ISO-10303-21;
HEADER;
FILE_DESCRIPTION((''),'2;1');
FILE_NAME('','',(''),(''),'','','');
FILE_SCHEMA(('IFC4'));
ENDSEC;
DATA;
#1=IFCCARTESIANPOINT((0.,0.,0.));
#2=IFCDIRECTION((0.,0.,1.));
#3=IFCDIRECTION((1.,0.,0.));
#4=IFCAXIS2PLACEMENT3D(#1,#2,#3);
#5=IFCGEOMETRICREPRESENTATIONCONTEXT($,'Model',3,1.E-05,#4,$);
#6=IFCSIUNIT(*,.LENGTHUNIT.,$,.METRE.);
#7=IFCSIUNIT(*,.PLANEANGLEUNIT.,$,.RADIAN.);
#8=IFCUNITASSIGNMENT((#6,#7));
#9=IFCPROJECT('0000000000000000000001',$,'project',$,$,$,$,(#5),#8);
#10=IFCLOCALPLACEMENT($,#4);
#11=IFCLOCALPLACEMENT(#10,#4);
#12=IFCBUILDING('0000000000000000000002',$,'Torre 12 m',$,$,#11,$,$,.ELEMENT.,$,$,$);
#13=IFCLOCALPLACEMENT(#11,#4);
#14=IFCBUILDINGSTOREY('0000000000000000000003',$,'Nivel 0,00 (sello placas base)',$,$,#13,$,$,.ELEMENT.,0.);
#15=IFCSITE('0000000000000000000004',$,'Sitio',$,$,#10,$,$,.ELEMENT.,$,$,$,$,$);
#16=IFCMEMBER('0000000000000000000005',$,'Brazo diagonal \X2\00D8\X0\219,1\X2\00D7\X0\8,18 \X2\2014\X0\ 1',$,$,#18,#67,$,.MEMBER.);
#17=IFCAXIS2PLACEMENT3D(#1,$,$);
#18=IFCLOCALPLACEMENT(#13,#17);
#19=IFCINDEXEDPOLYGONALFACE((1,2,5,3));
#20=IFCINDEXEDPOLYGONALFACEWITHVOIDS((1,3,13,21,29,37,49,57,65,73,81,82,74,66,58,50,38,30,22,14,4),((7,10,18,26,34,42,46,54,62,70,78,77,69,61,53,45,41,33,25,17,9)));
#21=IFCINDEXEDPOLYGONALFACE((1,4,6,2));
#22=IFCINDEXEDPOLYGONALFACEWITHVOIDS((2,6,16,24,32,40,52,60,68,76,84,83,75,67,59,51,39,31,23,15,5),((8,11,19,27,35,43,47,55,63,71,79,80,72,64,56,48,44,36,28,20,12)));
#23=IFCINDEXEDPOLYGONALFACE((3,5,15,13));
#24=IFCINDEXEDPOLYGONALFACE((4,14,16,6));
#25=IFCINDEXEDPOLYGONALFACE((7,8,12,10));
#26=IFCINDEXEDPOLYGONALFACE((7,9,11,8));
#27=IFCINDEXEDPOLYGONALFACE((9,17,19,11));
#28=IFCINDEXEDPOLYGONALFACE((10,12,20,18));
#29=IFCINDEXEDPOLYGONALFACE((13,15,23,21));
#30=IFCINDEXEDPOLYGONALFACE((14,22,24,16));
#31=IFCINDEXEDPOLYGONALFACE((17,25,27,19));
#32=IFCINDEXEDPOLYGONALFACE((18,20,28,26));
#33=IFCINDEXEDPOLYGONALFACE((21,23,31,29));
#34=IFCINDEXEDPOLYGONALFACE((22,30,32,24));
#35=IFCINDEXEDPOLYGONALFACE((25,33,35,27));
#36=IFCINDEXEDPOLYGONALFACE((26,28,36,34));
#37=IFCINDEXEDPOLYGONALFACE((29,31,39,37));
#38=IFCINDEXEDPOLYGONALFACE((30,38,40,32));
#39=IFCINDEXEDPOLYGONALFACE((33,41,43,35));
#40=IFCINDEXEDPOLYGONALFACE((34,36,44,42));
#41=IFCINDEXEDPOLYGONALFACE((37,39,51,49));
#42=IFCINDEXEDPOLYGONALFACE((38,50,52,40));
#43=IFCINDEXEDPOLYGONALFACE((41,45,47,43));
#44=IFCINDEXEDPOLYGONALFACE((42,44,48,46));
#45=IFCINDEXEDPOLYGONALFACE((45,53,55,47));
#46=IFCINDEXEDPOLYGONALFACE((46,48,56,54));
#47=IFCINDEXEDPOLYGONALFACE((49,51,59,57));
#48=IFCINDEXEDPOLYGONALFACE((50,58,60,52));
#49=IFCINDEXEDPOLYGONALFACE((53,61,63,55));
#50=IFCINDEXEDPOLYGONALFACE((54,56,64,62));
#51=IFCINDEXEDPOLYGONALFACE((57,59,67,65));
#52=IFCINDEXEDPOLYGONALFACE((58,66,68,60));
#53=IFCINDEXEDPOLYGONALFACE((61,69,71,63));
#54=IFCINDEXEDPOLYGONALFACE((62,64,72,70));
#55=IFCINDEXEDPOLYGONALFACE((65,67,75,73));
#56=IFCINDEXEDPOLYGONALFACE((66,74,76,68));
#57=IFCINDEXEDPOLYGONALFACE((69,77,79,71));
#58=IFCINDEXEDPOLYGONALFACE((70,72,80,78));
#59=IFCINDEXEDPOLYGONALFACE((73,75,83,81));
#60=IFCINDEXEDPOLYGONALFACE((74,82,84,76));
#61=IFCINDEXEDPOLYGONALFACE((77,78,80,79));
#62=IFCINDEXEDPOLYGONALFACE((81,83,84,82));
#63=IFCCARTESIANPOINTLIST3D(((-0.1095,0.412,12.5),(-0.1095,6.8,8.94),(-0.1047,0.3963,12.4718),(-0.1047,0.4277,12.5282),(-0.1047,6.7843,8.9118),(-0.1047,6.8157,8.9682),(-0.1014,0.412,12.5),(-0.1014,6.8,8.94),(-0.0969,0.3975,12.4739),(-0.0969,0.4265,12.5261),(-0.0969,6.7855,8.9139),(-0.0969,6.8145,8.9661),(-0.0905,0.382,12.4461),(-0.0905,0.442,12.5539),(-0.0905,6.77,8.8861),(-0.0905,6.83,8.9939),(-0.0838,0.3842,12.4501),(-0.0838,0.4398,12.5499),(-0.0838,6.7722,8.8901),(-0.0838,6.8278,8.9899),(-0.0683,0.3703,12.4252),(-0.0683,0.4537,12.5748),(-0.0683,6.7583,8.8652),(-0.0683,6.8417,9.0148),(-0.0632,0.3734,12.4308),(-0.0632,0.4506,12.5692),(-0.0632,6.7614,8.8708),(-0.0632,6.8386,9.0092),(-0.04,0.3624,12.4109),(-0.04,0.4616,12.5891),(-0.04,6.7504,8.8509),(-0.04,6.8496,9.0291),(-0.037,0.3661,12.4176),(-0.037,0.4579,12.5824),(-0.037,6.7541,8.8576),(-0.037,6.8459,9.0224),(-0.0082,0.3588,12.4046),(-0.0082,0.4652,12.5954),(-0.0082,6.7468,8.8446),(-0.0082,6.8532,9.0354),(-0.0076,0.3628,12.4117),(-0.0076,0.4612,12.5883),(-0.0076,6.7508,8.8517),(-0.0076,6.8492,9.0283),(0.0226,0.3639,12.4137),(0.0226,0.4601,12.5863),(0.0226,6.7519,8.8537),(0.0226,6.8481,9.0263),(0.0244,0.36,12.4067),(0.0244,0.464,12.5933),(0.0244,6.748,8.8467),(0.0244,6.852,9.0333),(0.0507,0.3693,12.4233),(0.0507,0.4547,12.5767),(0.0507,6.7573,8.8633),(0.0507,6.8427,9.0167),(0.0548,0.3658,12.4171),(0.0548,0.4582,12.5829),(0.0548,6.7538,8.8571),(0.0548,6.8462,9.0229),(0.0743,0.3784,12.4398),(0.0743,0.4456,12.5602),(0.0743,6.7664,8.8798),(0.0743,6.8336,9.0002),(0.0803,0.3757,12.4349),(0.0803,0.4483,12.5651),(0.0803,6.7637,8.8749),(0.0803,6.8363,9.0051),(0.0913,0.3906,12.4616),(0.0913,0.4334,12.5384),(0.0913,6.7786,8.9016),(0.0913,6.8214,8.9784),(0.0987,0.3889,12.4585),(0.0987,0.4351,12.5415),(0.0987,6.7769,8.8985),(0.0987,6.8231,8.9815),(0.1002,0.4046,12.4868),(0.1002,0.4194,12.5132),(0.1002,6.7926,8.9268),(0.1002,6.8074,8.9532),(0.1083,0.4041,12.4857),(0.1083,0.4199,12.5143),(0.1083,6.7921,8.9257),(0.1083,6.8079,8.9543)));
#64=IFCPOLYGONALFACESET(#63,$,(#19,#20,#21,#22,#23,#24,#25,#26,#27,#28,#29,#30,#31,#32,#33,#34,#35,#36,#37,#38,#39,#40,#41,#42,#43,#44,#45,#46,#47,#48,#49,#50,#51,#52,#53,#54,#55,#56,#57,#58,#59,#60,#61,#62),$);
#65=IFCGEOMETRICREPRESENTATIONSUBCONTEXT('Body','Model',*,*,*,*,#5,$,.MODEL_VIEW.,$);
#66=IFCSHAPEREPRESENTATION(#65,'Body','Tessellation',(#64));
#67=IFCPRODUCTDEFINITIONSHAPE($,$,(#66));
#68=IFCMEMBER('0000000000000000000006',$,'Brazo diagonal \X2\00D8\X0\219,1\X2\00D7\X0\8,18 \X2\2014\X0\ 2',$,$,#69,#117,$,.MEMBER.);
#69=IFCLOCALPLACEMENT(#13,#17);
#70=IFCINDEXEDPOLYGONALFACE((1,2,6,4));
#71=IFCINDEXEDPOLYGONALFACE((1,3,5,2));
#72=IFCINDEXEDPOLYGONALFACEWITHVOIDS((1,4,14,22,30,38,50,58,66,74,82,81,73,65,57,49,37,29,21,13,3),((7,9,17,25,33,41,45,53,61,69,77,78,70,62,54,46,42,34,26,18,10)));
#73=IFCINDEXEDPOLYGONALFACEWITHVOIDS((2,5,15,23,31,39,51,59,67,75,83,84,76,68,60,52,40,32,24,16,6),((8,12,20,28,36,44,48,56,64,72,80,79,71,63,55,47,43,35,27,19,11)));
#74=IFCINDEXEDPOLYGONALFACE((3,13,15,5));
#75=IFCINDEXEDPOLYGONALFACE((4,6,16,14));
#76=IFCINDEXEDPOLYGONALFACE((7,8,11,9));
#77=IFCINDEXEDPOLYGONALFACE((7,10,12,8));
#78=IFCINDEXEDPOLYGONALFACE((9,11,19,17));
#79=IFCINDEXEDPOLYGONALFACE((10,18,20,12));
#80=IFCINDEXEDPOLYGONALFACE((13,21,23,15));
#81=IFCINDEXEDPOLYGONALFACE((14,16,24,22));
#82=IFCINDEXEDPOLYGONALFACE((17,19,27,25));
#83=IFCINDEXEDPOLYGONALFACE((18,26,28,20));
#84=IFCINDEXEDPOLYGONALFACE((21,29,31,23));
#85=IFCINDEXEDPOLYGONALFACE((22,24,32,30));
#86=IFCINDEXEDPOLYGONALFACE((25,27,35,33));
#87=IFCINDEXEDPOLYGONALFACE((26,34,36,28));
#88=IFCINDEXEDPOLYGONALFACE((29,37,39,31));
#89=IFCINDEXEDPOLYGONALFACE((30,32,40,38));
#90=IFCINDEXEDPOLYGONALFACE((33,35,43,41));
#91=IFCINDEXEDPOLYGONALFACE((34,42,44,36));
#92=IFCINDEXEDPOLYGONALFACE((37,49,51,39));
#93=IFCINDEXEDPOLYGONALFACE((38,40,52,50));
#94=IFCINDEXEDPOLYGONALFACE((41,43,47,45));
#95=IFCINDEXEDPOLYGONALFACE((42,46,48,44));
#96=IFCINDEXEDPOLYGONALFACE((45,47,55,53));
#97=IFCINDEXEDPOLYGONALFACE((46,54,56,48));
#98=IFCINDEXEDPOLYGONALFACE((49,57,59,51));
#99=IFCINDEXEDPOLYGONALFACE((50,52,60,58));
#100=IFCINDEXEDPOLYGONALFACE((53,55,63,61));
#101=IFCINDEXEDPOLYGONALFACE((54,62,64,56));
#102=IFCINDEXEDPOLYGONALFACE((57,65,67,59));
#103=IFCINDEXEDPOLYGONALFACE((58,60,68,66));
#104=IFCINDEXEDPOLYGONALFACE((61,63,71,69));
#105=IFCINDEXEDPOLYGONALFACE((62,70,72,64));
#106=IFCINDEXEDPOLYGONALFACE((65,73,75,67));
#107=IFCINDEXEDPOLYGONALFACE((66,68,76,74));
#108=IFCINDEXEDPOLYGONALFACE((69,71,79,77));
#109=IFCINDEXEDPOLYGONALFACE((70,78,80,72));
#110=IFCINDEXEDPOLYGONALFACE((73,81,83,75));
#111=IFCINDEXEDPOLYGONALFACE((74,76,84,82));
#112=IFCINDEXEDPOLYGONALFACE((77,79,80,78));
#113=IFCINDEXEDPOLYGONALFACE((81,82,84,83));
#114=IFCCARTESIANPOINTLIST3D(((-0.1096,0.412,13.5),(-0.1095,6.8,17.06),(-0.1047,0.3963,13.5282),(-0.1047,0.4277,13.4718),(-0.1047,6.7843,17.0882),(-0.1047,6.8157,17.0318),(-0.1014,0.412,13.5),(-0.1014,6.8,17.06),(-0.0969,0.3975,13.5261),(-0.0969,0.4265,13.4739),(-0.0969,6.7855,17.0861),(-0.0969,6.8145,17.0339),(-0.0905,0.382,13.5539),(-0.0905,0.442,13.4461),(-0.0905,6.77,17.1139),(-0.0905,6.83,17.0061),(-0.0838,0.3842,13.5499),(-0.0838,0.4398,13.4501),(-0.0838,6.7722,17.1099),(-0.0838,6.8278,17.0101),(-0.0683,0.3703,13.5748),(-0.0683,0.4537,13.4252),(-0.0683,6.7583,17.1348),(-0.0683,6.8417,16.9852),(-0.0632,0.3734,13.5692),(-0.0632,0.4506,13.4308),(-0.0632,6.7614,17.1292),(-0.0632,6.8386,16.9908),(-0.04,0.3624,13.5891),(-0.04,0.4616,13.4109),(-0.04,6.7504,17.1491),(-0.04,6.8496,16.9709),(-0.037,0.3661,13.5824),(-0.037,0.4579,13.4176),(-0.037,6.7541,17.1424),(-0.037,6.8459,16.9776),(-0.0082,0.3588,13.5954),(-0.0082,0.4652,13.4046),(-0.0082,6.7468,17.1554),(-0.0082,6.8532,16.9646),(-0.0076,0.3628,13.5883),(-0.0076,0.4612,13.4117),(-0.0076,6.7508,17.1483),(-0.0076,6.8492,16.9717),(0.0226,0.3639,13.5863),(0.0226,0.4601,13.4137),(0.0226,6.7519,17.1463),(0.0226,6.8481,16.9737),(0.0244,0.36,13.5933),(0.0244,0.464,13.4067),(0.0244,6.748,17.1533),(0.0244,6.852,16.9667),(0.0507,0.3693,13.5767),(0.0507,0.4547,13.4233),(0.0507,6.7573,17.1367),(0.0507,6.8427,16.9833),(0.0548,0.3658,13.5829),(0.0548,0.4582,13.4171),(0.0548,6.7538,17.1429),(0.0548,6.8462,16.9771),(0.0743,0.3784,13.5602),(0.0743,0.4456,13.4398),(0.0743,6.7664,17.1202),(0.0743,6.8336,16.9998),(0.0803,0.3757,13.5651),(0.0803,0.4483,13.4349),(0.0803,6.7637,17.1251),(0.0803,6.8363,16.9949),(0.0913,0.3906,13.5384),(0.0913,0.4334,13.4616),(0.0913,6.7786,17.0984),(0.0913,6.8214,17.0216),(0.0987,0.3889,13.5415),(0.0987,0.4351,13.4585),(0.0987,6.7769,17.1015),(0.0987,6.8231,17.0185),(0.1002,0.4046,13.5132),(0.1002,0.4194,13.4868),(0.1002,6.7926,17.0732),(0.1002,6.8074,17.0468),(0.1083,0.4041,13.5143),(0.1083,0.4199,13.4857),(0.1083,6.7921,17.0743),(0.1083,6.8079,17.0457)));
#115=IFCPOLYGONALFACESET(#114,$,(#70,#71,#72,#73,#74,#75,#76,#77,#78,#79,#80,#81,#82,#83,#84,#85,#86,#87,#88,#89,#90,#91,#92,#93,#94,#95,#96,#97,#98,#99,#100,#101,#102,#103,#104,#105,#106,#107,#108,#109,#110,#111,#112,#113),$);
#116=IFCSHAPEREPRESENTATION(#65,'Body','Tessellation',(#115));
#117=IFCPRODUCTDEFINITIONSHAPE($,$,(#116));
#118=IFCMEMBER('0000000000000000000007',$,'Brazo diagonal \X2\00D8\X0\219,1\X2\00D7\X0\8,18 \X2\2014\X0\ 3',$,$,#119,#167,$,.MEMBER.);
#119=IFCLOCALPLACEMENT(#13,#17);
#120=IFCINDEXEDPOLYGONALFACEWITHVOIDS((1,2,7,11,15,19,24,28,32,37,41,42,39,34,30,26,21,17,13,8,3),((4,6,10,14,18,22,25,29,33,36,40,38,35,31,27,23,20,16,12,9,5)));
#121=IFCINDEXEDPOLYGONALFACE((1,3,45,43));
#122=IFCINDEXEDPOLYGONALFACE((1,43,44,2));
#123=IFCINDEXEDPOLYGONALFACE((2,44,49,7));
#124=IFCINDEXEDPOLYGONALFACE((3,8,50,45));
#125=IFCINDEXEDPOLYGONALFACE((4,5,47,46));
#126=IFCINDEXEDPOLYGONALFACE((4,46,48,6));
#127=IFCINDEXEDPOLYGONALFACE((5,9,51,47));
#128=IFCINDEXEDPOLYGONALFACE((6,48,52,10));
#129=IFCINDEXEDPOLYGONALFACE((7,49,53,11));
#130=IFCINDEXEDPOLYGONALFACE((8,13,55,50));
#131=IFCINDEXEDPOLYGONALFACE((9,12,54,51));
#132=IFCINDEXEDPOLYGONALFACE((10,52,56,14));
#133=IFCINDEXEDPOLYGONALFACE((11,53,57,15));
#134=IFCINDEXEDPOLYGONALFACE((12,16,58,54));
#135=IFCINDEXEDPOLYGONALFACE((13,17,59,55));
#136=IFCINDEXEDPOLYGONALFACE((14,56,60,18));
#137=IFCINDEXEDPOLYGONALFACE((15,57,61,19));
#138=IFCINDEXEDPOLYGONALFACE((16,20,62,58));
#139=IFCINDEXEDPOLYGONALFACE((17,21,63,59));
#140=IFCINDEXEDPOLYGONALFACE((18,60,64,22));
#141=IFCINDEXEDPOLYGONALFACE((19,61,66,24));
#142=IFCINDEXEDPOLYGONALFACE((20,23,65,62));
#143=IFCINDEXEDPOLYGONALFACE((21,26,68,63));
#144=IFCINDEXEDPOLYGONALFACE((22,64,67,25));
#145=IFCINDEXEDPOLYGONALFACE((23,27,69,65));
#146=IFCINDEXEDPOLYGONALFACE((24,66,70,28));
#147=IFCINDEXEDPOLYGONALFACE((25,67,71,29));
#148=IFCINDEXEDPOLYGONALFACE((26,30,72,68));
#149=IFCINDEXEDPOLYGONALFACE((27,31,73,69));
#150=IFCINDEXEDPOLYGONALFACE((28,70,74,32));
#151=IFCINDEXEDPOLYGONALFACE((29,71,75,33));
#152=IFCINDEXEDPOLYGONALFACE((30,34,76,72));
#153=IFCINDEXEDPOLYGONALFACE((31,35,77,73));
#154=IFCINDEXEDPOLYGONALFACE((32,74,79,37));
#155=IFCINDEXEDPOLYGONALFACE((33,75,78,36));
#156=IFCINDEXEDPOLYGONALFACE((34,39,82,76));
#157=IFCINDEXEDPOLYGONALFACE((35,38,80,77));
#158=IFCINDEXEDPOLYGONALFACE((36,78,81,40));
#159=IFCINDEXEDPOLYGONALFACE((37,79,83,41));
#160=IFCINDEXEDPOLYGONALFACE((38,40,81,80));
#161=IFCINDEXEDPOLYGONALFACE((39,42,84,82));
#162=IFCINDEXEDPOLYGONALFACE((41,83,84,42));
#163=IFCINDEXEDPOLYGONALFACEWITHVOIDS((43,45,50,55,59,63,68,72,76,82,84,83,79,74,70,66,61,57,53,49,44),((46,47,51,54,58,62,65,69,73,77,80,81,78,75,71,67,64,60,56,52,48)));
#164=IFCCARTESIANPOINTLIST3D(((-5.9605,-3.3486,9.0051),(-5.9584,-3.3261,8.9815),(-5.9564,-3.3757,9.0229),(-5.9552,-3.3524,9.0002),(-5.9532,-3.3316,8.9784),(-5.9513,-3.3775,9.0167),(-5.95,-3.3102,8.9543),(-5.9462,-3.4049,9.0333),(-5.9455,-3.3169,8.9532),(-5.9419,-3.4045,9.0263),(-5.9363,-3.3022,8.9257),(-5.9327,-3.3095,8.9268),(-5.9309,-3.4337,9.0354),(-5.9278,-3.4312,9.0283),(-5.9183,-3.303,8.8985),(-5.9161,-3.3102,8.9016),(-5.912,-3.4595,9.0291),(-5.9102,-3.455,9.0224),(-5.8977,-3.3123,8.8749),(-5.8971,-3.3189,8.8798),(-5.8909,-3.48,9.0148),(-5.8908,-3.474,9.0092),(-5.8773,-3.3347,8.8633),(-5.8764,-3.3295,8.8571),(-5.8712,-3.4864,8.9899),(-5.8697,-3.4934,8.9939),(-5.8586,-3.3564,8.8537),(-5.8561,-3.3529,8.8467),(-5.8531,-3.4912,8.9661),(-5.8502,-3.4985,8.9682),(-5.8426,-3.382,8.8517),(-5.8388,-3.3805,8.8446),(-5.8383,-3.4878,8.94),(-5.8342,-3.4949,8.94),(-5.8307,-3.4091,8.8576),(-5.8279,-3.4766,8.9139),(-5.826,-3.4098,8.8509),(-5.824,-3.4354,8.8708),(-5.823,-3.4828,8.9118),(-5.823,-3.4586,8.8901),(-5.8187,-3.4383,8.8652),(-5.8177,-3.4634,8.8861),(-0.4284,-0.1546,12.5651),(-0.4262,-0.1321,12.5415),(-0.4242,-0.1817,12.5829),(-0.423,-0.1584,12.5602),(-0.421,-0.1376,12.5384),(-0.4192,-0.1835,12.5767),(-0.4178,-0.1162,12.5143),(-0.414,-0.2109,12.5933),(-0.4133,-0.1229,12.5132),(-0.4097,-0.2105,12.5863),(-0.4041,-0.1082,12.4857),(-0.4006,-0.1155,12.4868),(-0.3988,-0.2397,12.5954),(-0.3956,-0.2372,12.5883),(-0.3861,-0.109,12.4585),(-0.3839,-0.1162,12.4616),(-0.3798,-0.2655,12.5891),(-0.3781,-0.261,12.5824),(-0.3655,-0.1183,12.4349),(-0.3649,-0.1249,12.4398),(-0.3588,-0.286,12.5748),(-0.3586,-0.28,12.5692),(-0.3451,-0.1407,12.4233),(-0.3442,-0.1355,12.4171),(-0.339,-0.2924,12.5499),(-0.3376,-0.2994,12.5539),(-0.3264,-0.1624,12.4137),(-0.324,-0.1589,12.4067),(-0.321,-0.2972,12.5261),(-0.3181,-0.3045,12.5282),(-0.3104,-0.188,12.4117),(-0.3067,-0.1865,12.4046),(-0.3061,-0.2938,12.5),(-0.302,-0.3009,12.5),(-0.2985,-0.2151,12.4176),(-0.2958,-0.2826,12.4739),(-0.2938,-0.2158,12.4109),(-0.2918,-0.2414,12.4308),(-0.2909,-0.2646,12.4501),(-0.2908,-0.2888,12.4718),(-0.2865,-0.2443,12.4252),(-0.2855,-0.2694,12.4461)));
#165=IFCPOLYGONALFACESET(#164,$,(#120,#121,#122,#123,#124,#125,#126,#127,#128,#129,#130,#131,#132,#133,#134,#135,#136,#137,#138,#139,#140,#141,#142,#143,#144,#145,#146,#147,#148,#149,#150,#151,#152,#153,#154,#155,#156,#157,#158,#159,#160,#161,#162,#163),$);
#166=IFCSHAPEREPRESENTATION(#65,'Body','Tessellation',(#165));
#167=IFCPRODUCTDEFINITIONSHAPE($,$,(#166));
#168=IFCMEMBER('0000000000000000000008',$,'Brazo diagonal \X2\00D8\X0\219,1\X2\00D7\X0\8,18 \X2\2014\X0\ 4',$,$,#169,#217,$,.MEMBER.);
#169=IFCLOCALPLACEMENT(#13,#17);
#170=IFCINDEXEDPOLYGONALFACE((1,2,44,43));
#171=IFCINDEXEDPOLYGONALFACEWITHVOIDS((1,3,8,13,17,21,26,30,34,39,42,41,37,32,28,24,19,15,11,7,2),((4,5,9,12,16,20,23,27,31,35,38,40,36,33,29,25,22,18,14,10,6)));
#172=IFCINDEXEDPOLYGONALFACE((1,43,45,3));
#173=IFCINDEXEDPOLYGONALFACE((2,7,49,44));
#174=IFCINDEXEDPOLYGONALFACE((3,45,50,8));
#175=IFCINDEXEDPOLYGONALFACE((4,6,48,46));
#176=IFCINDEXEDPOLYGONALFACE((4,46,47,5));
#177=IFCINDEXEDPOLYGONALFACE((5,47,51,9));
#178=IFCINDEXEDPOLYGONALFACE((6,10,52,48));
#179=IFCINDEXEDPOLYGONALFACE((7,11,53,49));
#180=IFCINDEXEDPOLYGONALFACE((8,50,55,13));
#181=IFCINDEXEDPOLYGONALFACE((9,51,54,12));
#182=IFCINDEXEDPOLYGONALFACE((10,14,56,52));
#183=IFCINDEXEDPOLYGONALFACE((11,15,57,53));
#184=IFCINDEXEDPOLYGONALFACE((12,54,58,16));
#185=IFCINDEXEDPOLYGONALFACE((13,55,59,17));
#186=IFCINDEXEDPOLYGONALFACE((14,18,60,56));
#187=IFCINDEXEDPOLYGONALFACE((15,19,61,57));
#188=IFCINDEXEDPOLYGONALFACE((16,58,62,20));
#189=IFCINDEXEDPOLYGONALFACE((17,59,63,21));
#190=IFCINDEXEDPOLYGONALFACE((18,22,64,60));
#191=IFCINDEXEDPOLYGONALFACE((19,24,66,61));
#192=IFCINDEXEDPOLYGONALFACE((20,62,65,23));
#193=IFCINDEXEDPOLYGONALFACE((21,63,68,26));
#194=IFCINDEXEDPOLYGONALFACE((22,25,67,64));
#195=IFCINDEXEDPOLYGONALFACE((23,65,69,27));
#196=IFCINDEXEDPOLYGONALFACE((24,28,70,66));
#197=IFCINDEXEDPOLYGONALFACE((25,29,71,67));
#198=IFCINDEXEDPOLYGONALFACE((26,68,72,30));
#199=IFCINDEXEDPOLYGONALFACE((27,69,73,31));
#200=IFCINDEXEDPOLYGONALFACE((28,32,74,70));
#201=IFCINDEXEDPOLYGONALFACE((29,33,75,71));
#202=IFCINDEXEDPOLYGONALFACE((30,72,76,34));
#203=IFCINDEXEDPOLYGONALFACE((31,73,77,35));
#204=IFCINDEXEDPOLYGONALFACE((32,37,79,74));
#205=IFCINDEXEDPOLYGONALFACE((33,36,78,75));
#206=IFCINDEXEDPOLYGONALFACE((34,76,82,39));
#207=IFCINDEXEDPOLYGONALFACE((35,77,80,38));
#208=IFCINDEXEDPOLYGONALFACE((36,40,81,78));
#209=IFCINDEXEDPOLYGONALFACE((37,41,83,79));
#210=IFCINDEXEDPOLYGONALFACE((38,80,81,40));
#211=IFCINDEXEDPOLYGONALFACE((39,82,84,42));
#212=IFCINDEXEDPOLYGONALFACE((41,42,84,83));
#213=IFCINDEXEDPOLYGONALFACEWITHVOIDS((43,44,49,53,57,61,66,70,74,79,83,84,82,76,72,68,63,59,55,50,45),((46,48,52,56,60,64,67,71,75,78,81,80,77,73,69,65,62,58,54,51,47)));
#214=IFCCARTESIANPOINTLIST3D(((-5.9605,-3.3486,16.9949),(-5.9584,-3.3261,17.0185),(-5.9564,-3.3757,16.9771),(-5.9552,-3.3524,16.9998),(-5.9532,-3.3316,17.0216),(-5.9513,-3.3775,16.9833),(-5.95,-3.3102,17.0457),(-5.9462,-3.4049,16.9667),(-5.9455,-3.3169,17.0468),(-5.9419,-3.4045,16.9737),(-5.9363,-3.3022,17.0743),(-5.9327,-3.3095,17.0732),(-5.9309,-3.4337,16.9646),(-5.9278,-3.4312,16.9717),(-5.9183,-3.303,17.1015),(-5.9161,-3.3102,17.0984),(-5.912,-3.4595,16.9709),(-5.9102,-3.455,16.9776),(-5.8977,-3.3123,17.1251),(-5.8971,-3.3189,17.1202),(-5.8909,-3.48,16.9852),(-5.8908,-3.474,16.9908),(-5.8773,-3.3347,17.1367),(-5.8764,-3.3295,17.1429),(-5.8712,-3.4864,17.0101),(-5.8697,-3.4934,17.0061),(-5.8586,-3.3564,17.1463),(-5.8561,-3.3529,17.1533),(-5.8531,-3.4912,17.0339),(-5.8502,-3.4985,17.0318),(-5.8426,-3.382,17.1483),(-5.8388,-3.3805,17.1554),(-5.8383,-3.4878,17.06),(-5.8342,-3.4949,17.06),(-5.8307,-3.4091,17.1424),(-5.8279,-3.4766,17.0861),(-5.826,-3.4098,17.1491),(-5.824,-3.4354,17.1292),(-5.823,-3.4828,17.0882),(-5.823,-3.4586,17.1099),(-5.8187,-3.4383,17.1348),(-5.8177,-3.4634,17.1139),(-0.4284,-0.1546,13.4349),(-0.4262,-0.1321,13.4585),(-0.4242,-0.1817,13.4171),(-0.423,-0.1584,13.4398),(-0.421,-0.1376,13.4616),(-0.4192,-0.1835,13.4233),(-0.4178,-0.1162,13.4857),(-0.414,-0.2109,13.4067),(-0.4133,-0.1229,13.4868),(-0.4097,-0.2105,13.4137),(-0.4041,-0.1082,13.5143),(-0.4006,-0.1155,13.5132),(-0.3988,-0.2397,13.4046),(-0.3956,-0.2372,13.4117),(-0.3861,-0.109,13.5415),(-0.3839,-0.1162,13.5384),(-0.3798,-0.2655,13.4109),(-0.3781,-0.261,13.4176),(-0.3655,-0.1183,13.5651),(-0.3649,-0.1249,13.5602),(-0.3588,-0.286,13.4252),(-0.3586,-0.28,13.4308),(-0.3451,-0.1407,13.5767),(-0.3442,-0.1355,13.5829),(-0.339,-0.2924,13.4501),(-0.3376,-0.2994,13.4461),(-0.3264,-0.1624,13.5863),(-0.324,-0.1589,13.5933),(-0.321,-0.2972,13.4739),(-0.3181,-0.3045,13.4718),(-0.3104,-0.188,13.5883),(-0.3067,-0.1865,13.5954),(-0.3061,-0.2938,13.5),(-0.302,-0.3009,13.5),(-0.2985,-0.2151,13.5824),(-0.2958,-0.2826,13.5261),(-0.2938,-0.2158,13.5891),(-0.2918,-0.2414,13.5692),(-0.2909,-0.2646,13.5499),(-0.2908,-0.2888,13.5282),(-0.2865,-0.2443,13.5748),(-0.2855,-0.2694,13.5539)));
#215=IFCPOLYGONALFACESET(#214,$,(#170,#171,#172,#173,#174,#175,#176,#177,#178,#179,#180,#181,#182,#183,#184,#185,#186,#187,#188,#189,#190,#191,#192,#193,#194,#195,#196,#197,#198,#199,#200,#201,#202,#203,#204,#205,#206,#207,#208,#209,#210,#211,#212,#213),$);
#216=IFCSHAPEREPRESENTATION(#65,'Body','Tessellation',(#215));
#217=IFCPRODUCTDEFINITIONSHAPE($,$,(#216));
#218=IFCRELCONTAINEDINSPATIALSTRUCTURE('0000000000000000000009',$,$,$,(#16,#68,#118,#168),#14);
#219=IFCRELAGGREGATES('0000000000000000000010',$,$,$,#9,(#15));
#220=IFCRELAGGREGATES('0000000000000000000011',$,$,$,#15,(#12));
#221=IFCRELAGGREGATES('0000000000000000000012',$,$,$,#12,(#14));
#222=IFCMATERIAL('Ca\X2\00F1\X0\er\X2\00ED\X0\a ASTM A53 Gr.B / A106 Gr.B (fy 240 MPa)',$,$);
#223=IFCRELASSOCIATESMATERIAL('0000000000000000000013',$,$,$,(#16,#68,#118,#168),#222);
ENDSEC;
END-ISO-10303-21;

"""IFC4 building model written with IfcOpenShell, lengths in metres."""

from ifc_helpers import new_model, si_unit, frame, origin, origin_with_axes, origin_2d, place, context, subcontext, project, spatial, hollow_circle, extrude, material, element, save


model = new_model("IFC4")

# Units and contexts
model_context = context("Model", 3, precision=1e-05, world=origin_with_axes())
body_context = subcontext(model_context, "Body", "Model", "MODEL_VIEW")
ifc_project = project(units=[si_unit("LENGTHUNIT", "METRE"), si_unit("PLANEANGLEUNIT", "RADIAN")], contexts=[model_context])

# Site, building, storey
site_placement = place(None, origin_with_axes())
site = spatial("IfcSite", under=ifc_project, at=site_placement, Name="Sitio", CompositionType="ELEMENT")
building_placement = place(site_placement, origin_with_axes())
building = spatial("IfcBuilding", under=site, at=building_placement, Name="Torre 12 m", CompositionType="ELEMENT")
storey_placement = place(building_placement, origin_with_axes())
storey = spatial("IfcBuildingStorey", under=building, at=storey_placement, Name="Nivel 0,00 (sello placas base)", CompositionType="ELEMENT", Elevation=0.0)

# Members
ifc_material_1 = material(Name="Cañería ASTM A53 Gr.B / A106 Gr.B (fy 240 MPa)")
for number, where, z_axis, x_axis, name in (
    (1, (0.0, 0.412, 12.5), (0.0, 0.873511, -0.486804), (-1.0, 0.0, 0.0), "Brazo diagonal Ø219,1×8,18 — 1"),
    (2, (0.0, 0.412, 13.5), (0.0, 0.873511, 0.486804), (-1.0, 0.0, 0.0), "Brazo diagonal Ø219,1×8,18 — 2"),
    (3, (-0.3568, -0.206, 12.5), (-0.756483, -0.436756, -0.486804), (0.5, -0.866025, 0.0), "Brazo diagonal Ø219,1×8,18 — 3"),
    (4, (-0.3568, -0.206, 13.5), (-0.756483, -0.436756, 0.486804), (0.5, -0.866025, 0.0), "Brazo diagonal Ø219,1×8,18 — 4"),
):
    element("IfcMember", number, at=place(storey_placement, frame(where, z_axis=z_axis, x_axis=x_axis)), inside=storey, material=ifc_material_1, Name=name, PredefinedType="MEMBER", context=body_context, shape_type="SweptSolid", body=[
        extrude(hollow_circle(Radius=0.1095, WallThickness=0.0082, at=origin_2d()), origin(), (0.0, 0.0, 1.0), 7.313),
    ])

save(model, "model.ifc")
